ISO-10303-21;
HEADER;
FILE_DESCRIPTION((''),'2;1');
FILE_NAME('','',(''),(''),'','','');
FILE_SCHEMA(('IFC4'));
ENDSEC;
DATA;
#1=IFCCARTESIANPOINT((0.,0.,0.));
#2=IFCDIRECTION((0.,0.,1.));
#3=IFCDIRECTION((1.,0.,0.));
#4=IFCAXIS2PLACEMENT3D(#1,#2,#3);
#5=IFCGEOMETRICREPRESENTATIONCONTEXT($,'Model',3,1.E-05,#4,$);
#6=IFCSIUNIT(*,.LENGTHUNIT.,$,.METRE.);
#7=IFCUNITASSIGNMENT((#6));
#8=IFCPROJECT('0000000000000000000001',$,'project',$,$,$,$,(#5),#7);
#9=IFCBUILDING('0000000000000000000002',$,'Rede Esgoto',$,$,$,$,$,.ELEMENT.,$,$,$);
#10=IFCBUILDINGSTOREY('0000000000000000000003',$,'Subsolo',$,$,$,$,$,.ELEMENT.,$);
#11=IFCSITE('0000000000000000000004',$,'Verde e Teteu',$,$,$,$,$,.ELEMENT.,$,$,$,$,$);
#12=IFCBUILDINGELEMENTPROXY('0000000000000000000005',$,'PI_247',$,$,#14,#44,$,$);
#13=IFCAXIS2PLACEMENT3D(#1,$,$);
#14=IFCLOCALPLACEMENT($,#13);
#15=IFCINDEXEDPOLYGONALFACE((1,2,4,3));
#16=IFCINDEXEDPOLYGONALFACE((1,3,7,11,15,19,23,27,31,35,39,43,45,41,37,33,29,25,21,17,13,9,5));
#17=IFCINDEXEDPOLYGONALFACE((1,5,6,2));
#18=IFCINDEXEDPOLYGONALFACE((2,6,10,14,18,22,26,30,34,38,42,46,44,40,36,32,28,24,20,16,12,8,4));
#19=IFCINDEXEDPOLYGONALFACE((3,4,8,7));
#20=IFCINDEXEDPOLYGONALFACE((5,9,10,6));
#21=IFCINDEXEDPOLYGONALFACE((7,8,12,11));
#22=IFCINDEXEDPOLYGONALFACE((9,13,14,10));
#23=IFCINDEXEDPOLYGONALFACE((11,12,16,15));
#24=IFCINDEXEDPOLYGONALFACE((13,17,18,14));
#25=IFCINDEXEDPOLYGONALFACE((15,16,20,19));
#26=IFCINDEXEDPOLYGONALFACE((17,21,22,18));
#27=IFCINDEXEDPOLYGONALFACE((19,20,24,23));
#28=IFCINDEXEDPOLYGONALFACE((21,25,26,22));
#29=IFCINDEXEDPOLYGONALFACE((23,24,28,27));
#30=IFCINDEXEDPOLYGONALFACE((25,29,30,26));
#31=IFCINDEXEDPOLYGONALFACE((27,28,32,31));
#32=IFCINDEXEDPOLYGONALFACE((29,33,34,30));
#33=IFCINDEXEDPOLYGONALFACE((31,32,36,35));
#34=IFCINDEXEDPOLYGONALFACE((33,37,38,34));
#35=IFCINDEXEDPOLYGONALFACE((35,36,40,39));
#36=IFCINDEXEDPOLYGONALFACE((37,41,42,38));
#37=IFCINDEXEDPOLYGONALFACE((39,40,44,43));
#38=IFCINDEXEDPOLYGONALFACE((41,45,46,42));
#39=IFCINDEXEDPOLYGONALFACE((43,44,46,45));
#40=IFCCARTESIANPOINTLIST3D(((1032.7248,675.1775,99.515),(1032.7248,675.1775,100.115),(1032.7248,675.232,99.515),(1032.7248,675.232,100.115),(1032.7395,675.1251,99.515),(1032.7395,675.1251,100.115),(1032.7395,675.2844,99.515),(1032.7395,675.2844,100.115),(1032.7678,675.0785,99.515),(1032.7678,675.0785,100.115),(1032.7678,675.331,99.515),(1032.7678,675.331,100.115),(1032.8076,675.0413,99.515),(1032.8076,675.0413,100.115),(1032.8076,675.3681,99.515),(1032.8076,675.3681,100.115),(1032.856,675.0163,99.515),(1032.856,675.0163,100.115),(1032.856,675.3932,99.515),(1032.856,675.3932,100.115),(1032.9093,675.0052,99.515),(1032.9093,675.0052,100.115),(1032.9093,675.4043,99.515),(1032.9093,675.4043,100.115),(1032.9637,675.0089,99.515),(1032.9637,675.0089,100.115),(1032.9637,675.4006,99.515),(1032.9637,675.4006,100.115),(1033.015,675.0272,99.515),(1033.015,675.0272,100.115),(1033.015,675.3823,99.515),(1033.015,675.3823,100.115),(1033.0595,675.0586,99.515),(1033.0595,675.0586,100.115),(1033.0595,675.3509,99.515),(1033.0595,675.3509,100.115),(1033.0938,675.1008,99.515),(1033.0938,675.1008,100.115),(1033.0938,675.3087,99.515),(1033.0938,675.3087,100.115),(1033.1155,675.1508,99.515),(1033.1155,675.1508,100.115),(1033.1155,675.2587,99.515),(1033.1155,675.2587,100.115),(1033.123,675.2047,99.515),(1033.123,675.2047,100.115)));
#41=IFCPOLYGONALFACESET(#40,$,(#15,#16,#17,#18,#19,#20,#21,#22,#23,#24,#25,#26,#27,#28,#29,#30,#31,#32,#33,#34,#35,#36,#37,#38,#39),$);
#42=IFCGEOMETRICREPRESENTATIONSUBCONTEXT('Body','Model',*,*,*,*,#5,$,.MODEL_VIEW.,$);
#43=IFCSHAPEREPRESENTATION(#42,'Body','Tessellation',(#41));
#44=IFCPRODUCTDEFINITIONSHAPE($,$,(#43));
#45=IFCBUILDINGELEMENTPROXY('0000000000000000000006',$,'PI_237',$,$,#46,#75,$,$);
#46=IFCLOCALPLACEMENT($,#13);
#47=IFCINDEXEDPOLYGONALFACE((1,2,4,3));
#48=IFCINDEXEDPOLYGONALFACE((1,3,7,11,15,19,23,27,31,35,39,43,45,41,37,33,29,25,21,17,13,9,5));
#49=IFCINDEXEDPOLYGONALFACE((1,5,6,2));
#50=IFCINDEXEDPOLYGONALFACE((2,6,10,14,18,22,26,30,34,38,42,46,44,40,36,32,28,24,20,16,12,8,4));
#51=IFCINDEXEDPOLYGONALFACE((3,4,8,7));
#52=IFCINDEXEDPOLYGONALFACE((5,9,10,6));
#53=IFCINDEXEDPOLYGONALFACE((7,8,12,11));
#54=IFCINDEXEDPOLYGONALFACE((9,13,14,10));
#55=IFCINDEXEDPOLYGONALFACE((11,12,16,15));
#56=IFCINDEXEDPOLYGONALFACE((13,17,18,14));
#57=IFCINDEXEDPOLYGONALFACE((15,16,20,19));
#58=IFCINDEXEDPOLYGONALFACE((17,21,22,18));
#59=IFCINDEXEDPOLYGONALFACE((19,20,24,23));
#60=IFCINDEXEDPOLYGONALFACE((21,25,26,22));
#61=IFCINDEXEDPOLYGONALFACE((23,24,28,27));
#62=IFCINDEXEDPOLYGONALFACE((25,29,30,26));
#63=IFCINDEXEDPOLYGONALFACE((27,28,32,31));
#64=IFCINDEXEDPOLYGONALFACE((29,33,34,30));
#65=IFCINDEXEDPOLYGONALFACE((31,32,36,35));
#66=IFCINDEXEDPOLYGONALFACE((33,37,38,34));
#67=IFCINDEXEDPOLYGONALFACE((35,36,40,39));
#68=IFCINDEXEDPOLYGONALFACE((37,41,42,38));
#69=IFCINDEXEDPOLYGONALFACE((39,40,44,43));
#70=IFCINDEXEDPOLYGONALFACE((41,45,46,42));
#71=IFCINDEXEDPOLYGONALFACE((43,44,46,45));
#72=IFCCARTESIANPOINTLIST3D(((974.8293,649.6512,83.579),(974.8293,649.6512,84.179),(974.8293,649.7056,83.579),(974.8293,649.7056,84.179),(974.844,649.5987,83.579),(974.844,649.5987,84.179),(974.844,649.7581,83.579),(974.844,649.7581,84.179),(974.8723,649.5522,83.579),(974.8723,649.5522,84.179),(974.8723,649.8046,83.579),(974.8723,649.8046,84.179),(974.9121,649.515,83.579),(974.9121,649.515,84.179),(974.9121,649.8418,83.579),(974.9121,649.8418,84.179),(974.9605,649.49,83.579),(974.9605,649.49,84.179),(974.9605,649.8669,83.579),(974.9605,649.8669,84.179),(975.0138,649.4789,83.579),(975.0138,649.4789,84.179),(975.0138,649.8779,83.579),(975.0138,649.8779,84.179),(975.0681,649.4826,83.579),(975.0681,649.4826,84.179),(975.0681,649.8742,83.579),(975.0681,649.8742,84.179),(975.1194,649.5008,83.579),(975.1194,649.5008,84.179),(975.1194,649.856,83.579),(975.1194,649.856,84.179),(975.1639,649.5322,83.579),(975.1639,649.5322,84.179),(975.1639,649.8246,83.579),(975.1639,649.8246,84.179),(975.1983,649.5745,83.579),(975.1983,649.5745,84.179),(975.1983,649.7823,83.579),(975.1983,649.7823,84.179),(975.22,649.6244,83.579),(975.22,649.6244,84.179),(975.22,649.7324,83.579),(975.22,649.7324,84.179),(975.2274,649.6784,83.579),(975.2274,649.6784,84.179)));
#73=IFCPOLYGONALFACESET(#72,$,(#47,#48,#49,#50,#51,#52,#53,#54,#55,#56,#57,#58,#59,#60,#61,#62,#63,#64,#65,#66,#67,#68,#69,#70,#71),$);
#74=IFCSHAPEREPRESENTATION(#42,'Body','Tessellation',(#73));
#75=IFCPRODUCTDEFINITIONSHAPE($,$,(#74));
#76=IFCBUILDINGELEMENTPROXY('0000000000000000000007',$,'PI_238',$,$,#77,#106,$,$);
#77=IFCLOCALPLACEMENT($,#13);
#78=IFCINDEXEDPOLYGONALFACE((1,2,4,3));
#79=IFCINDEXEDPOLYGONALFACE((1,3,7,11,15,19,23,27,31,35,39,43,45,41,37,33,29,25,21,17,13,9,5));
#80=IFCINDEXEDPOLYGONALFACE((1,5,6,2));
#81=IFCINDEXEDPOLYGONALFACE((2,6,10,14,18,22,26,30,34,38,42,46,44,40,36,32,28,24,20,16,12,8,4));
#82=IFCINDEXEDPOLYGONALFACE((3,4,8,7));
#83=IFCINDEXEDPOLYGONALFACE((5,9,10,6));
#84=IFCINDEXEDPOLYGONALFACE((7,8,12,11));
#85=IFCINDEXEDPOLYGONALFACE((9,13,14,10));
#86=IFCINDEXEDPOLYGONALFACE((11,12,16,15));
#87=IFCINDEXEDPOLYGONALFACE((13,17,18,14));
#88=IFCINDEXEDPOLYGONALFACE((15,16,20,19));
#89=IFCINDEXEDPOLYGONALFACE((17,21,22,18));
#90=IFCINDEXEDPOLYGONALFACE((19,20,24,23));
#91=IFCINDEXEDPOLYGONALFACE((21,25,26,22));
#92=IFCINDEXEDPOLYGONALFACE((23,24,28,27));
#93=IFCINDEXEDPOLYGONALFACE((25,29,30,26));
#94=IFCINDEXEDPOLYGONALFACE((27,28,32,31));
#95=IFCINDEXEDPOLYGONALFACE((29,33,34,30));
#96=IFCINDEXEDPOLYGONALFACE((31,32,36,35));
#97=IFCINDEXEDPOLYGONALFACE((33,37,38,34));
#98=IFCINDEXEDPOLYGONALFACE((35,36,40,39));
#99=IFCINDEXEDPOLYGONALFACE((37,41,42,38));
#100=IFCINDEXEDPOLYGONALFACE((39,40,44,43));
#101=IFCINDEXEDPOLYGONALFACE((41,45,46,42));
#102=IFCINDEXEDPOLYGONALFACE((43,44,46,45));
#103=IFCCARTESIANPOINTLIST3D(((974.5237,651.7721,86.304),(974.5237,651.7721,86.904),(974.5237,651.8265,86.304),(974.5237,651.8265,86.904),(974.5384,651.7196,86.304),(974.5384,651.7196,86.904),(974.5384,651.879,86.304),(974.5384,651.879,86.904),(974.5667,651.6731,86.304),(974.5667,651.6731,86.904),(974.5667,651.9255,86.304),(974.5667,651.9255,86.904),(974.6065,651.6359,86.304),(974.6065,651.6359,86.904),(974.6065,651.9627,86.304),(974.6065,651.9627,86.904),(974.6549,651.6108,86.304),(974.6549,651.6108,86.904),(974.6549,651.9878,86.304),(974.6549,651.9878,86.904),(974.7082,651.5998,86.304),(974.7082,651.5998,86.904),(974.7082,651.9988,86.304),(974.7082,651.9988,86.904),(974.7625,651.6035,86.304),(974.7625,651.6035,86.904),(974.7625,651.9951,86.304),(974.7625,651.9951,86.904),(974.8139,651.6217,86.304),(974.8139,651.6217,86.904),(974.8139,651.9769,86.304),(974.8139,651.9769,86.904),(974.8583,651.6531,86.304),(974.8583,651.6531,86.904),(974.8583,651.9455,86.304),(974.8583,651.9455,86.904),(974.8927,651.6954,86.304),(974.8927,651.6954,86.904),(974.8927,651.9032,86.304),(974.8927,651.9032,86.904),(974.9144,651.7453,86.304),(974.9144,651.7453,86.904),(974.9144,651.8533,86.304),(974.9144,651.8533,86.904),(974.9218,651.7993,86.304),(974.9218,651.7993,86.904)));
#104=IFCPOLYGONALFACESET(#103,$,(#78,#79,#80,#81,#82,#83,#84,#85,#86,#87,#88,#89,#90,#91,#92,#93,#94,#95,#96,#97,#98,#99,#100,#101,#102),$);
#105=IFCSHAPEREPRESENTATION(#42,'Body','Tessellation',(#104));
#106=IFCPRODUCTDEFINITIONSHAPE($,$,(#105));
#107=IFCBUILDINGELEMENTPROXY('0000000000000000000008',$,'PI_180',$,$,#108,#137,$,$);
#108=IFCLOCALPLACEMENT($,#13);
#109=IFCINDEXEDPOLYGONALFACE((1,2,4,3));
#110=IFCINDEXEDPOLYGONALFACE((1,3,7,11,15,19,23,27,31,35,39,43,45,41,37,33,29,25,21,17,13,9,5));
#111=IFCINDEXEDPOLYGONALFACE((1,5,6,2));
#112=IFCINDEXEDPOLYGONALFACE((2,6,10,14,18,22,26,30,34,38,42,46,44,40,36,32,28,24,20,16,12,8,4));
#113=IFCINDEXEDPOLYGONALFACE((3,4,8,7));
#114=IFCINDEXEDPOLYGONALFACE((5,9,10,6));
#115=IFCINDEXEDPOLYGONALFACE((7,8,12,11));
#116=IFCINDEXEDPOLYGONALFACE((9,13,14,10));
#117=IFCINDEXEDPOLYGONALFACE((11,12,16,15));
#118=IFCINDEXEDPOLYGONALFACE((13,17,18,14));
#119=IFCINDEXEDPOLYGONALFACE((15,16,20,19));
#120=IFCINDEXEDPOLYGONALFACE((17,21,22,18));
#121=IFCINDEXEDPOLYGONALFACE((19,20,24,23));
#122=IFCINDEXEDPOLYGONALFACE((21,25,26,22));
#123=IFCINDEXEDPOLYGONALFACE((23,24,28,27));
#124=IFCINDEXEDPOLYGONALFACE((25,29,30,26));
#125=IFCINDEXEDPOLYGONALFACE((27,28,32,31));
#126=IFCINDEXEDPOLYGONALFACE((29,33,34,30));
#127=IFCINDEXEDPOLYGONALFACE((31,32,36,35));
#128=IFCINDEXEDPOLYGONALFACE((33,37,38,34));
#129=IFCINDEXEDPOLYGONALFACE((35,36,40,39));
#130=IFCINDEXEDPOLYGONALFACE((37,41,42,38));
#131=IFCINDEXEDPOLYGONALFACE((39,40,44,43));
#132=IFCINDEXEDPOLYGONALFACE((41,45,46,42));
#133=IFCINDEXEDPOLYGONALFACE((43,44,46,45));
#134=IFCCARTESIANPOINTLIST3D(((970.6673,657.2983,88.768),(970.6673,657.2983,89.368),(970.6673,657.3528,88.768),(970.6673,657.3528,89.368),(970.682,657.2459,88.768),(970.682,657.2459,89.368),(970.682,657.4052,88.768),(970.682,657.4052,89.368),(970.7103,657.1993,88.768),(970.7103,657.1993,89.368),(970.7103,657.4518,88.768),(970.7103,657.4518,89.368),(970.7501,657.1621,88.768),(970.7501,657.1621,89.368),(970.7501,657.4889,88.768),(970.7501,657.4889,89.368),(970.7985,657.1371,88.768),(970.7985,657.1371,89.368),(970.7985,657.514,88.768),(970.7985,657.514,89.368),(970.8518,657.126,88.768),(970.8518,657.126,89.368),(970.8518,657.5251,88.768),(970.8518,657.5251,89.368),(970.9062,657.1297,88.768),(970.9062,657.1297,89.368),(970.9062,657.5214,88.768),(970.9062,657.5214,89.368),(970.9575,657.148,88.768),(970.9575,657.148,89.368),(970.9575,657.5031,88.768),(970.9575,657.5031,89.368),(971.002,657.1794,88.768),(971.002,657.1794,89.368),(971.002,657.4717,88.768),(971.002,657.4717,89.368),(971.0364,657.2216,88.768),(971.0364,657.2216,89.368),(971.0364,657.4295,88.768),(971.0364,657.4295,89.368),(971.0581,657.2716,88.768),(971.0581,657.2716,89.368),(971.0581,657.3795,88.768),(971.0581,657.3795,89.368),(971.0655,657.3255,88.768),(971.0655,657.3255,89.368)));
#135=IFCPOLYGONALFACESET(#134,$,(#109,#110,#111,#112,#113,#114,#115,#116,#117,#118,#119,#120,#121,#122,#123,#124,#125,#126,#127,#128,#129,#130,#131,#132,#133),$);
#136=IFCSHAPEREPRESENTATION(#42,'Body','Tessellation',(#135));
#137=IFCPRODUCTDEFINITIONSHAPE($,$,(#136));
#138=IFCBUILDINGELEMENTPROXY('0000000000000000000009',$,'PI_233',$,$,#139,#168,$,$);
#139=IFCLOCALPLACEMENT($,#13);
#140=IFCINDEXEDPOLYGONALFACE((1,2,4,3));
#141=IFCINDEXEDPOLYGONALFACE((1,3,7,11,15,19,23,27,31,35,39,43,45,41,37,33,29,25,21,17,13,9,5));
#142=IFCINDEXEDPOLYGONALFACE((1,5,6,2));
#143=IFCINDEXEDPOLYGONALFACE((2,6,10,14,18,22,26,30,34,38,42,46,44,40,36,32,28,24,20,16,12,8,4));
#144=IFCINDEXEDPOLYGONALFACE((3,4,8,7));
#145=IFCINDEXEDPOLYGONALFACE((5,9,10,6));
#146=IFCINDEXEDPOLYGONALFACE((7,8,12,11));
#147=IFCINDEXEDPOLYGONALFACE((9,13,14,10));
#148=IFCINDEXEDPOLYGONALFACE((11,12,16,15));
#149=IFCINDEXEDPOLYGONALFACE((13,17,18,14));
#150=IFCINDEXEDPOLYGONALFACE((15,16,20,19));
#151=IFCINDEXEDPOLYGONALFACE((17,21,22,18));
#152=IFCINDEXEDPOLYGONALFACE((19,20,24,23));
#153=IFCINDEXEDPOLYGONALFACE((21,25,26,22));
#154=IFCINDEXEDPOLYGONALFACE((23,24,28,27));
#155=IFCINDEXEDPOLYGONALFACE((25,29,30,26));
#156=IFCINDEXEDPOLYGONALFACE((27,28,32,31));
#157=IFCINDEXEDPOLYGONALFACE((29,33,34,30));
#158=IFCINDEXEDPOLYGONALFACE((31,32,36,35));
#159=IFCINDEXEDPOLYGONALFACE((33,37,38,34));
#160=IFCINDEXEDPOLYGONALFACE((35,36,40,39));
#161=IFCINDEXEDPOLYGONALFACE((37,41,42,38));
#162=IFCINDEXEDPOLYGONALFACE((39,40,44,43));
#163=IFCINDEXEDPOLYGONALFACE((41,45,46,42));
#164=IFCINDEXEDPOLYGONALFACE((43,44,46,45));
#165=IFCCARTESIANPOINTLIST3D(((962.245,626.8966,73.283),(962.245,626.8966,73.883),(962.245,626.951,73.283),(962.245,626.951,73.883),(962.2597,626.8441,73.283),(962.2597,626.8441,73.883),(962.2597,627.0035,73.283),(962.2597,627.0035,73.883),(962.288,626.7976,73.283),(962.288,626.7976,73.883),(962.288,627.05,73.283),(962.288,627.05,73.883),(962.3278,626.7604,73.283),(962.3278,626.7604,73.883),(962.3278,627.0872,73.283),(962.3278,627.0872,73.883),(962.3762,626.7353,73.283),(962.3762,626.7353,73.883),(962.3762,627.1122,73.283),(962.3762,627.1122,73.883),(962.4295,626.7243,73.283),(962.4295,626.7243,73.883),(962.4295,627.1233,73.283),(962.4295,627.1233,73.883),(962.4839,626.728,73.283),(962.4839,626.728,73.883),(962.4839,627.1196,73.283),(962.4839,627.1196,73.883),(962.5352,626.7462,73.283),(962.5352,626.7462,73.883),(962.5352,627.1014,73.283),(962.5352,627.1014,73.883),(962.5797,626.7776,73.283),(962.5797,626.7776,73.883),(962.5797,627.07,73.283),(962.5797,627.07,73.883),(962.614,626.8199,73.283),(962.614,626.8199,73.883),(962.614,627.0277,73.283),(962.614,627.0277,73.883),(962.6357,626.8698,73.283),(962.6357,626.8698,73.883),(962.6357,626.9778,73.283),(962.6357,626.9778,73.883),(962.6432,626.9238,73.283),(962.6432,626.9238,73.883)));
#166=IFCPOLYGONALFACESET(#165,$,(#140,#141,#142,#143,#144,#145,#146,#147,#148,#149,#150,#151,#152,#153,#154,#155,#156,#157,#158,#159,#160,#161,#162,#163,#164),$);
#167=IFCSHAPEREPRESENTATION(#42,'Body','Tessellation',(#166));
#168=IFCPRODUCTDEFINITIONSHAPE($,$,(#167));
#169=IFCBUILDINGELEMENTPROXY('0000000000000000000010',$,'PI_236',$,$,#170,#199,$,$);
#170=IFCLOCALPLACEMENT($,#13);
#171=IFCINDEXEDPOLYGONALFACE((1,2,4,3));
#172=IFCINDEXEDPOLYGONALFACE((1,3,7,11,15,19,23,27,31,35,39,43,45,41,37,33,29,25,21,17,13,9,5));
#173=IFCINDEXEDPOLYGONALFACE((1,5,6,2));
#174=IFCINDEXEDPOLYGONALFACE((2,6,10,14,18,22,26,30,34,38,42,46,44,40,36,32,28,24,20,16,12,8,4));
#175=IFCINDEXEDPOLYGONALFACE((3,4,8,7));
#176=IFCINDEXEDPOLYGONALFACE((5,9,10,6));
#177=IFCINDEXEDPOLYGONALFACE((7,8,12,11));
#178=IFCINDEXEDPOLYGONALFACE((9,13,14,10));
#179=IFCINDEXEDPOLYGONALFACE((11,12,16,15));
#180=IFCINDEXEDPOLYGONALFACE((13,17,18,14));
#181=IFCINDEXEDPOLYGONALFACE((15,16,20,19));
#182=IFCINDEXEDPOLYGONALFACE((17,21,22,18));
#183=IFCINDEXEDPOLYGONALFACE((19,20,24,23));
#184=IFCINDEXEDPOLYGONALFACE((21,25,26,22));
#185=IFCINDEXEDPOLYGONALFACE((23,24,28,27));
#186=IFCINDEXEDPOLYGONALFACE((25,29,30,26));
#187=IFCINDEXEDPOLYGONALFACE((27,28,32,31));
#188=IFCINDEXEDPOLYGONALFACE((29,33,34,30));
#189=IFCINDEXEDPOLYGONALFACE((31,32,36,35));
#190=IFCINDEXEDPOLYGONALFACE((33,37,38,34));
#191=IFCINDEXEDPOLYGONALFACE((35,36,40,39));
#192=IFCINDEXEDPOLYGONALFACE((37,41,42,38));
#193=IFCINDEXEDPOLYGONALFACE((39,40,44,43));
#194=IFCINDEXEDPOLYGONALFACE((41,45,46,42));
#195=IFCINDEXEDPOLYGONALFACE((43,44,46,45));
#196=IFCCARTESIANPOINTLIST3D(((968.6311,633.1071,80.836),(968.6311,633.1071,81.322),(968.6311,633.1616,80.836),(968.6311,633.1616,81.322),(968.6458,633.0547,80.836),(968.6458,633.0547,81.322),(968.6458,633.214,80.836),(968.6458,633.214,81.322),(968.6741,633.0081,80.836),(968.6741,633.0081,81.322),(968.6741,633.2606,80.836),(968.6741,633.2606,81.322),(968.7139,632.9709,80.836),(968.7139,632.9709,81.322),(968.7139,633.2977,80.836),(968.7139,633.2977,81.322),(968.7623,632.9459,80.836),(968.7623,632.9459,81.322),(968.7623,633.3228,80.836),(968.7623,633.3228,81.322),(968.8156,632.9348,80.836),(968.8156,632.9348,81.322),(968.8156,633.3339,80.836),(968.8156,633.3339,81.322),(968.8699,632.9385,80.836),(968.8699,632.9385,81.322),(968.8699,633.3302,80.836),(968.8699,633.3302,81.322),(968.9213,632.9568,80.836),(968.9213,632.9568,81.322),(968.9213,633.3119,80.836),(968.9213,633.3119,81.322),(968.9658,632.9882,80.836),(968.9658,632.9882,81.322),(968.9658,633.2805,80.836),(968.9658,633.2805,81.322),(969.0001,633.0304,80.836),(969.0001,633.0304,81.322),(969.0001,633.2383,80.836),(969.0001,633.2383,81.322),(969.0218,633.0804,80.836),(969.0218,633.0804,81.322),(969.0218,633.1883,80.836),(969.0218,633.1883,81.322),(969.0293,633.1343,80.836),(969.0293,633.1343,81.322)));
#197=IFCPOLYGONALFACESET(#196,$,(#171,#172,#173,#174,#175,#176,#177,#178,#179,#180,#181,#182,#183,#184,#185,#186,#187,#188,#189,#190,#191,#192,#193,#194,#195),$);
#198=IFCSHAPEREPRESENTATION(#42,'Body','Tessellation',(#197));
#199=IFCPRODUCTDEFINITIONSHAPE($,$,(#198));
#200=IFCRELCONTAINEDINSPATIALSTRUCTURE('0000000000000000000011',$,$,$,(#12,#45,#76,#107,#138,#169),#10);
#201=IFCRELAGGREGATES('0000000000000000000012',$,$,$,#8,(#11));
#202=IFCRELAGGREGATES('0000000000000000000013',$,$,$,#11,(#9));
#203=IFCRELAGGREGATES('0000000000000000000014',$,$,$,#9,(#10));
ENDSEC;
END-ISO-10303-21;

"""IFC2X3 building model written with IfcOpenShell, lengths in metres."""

from ifc_helpers import new_model, si_unit, frame, origin_with_axes, origin_2d, place, context, subcontext, project, spatial, circle, extrude, element, save


model = new_model("IFC2X3")

# Units and contexts
model_context = context("Model", 3, precision=1e-05, world=origin_with_axes())
body_context = subcontext(model_context, "Body", "Model", "MODEL_VIEW")
ifc_project = project(units=[si_unit("LENGTHUNIT", "METRE")], contexts=[model_context])

# Site, building, storey
site = spatial("IfcSite", under=ifc_project, Name="Verde e Teteu", CompositionType="ELEMENT")
building = spatial("IfcBuilding", under=site, Name="Rede Esgoto", CompositionType="ELEMENT")
storey = spatial("IfcBuildingStorey", under=building, Name="Subsolo", CompositionType="ELEMENT")

# Building element proxies
for number, where, z_axis, x_axis, name in (
    (1, (1032.923, 675.2047, 99.515), (0.0, 0.0, 1.0), (1.0, 0.0, 0.0), "PI_247"),
):
    element("IfcBuildingElementProxy", number, at=place(None, frame(where, z_axis=z_axis, x_axis=x_axis)), inside=storey, Name=name, context=body_context, shape_type="SweptSolid", body=[
        extrude(circle(Radius=0.2, at=origin_2d()), origin_with_axes(), (0.0, 0.0, 1.0), 0.6),
    ])
proxy_1_placement = place(None, frame((975.0274, 649.6784, 83.579), z_axis=(0.0, 0.0, 1.0), x_axis=(1.0, 0.0, 0.0)))
element("IfcBuildingElementProxy", 2, at=proxy_1_placement, inside=storey, Name="PI_237", context=body_context, shape_type="SweptSolid", body=[
    extrude(circle(Radius=0.2, at=origin_2d()), origin_with_axes(), (0.0, 0.0, 1.0), 0.6),
])
for number, where, z_axis, x_axis, name in (
    (3, (974.7218, 651.7993, 86.304), (0.0, 0.0, 1.0), (1.0, 0.0, 0.0), "PI_238"),
    (4, (970.8655, 657.3255, 88.768), (0.0, 0.0, 1.0), (1.0, 0.0, 0.0), "PI_180"),
    (5, (962.4432, 626.9238, 73.283), (0.0, 0.0, 1.0), (1.0, 0.0, 0.0), "PI_233"),
):
    element("IfcBuildingElementProxy", number, at=place(None, frame(where, z_axis=z_axis, x_axis=x_axis)), inside=storey, Name=name, context=body_context, shape_type="SweptSolid", body=[
        extrude(circle(Radius=0.2, at=origin_2d()), origin_with_axes(), (0.0, 0.0, 1.0), 0.6),
    ])
proxy_2_placement = place(None, frame((968.8293, 633.1343, 80.836), z_axis=(0.0, 0.0, 1.0), x_axis=(1.0, 0.0, 0.0)))
element("IfcBuildingElementProxy", 6, at=proxy_2_placement, inside=storey, Name="PI_236", context=body_context, shape_type="SweptSolid", body=[
    extrude(circle(Radius=0.2, at=origin_2d()), origin_with_axes(), (0.0, 0.0, 1.0), 0.486),
])

save(model, "model.ifc")
